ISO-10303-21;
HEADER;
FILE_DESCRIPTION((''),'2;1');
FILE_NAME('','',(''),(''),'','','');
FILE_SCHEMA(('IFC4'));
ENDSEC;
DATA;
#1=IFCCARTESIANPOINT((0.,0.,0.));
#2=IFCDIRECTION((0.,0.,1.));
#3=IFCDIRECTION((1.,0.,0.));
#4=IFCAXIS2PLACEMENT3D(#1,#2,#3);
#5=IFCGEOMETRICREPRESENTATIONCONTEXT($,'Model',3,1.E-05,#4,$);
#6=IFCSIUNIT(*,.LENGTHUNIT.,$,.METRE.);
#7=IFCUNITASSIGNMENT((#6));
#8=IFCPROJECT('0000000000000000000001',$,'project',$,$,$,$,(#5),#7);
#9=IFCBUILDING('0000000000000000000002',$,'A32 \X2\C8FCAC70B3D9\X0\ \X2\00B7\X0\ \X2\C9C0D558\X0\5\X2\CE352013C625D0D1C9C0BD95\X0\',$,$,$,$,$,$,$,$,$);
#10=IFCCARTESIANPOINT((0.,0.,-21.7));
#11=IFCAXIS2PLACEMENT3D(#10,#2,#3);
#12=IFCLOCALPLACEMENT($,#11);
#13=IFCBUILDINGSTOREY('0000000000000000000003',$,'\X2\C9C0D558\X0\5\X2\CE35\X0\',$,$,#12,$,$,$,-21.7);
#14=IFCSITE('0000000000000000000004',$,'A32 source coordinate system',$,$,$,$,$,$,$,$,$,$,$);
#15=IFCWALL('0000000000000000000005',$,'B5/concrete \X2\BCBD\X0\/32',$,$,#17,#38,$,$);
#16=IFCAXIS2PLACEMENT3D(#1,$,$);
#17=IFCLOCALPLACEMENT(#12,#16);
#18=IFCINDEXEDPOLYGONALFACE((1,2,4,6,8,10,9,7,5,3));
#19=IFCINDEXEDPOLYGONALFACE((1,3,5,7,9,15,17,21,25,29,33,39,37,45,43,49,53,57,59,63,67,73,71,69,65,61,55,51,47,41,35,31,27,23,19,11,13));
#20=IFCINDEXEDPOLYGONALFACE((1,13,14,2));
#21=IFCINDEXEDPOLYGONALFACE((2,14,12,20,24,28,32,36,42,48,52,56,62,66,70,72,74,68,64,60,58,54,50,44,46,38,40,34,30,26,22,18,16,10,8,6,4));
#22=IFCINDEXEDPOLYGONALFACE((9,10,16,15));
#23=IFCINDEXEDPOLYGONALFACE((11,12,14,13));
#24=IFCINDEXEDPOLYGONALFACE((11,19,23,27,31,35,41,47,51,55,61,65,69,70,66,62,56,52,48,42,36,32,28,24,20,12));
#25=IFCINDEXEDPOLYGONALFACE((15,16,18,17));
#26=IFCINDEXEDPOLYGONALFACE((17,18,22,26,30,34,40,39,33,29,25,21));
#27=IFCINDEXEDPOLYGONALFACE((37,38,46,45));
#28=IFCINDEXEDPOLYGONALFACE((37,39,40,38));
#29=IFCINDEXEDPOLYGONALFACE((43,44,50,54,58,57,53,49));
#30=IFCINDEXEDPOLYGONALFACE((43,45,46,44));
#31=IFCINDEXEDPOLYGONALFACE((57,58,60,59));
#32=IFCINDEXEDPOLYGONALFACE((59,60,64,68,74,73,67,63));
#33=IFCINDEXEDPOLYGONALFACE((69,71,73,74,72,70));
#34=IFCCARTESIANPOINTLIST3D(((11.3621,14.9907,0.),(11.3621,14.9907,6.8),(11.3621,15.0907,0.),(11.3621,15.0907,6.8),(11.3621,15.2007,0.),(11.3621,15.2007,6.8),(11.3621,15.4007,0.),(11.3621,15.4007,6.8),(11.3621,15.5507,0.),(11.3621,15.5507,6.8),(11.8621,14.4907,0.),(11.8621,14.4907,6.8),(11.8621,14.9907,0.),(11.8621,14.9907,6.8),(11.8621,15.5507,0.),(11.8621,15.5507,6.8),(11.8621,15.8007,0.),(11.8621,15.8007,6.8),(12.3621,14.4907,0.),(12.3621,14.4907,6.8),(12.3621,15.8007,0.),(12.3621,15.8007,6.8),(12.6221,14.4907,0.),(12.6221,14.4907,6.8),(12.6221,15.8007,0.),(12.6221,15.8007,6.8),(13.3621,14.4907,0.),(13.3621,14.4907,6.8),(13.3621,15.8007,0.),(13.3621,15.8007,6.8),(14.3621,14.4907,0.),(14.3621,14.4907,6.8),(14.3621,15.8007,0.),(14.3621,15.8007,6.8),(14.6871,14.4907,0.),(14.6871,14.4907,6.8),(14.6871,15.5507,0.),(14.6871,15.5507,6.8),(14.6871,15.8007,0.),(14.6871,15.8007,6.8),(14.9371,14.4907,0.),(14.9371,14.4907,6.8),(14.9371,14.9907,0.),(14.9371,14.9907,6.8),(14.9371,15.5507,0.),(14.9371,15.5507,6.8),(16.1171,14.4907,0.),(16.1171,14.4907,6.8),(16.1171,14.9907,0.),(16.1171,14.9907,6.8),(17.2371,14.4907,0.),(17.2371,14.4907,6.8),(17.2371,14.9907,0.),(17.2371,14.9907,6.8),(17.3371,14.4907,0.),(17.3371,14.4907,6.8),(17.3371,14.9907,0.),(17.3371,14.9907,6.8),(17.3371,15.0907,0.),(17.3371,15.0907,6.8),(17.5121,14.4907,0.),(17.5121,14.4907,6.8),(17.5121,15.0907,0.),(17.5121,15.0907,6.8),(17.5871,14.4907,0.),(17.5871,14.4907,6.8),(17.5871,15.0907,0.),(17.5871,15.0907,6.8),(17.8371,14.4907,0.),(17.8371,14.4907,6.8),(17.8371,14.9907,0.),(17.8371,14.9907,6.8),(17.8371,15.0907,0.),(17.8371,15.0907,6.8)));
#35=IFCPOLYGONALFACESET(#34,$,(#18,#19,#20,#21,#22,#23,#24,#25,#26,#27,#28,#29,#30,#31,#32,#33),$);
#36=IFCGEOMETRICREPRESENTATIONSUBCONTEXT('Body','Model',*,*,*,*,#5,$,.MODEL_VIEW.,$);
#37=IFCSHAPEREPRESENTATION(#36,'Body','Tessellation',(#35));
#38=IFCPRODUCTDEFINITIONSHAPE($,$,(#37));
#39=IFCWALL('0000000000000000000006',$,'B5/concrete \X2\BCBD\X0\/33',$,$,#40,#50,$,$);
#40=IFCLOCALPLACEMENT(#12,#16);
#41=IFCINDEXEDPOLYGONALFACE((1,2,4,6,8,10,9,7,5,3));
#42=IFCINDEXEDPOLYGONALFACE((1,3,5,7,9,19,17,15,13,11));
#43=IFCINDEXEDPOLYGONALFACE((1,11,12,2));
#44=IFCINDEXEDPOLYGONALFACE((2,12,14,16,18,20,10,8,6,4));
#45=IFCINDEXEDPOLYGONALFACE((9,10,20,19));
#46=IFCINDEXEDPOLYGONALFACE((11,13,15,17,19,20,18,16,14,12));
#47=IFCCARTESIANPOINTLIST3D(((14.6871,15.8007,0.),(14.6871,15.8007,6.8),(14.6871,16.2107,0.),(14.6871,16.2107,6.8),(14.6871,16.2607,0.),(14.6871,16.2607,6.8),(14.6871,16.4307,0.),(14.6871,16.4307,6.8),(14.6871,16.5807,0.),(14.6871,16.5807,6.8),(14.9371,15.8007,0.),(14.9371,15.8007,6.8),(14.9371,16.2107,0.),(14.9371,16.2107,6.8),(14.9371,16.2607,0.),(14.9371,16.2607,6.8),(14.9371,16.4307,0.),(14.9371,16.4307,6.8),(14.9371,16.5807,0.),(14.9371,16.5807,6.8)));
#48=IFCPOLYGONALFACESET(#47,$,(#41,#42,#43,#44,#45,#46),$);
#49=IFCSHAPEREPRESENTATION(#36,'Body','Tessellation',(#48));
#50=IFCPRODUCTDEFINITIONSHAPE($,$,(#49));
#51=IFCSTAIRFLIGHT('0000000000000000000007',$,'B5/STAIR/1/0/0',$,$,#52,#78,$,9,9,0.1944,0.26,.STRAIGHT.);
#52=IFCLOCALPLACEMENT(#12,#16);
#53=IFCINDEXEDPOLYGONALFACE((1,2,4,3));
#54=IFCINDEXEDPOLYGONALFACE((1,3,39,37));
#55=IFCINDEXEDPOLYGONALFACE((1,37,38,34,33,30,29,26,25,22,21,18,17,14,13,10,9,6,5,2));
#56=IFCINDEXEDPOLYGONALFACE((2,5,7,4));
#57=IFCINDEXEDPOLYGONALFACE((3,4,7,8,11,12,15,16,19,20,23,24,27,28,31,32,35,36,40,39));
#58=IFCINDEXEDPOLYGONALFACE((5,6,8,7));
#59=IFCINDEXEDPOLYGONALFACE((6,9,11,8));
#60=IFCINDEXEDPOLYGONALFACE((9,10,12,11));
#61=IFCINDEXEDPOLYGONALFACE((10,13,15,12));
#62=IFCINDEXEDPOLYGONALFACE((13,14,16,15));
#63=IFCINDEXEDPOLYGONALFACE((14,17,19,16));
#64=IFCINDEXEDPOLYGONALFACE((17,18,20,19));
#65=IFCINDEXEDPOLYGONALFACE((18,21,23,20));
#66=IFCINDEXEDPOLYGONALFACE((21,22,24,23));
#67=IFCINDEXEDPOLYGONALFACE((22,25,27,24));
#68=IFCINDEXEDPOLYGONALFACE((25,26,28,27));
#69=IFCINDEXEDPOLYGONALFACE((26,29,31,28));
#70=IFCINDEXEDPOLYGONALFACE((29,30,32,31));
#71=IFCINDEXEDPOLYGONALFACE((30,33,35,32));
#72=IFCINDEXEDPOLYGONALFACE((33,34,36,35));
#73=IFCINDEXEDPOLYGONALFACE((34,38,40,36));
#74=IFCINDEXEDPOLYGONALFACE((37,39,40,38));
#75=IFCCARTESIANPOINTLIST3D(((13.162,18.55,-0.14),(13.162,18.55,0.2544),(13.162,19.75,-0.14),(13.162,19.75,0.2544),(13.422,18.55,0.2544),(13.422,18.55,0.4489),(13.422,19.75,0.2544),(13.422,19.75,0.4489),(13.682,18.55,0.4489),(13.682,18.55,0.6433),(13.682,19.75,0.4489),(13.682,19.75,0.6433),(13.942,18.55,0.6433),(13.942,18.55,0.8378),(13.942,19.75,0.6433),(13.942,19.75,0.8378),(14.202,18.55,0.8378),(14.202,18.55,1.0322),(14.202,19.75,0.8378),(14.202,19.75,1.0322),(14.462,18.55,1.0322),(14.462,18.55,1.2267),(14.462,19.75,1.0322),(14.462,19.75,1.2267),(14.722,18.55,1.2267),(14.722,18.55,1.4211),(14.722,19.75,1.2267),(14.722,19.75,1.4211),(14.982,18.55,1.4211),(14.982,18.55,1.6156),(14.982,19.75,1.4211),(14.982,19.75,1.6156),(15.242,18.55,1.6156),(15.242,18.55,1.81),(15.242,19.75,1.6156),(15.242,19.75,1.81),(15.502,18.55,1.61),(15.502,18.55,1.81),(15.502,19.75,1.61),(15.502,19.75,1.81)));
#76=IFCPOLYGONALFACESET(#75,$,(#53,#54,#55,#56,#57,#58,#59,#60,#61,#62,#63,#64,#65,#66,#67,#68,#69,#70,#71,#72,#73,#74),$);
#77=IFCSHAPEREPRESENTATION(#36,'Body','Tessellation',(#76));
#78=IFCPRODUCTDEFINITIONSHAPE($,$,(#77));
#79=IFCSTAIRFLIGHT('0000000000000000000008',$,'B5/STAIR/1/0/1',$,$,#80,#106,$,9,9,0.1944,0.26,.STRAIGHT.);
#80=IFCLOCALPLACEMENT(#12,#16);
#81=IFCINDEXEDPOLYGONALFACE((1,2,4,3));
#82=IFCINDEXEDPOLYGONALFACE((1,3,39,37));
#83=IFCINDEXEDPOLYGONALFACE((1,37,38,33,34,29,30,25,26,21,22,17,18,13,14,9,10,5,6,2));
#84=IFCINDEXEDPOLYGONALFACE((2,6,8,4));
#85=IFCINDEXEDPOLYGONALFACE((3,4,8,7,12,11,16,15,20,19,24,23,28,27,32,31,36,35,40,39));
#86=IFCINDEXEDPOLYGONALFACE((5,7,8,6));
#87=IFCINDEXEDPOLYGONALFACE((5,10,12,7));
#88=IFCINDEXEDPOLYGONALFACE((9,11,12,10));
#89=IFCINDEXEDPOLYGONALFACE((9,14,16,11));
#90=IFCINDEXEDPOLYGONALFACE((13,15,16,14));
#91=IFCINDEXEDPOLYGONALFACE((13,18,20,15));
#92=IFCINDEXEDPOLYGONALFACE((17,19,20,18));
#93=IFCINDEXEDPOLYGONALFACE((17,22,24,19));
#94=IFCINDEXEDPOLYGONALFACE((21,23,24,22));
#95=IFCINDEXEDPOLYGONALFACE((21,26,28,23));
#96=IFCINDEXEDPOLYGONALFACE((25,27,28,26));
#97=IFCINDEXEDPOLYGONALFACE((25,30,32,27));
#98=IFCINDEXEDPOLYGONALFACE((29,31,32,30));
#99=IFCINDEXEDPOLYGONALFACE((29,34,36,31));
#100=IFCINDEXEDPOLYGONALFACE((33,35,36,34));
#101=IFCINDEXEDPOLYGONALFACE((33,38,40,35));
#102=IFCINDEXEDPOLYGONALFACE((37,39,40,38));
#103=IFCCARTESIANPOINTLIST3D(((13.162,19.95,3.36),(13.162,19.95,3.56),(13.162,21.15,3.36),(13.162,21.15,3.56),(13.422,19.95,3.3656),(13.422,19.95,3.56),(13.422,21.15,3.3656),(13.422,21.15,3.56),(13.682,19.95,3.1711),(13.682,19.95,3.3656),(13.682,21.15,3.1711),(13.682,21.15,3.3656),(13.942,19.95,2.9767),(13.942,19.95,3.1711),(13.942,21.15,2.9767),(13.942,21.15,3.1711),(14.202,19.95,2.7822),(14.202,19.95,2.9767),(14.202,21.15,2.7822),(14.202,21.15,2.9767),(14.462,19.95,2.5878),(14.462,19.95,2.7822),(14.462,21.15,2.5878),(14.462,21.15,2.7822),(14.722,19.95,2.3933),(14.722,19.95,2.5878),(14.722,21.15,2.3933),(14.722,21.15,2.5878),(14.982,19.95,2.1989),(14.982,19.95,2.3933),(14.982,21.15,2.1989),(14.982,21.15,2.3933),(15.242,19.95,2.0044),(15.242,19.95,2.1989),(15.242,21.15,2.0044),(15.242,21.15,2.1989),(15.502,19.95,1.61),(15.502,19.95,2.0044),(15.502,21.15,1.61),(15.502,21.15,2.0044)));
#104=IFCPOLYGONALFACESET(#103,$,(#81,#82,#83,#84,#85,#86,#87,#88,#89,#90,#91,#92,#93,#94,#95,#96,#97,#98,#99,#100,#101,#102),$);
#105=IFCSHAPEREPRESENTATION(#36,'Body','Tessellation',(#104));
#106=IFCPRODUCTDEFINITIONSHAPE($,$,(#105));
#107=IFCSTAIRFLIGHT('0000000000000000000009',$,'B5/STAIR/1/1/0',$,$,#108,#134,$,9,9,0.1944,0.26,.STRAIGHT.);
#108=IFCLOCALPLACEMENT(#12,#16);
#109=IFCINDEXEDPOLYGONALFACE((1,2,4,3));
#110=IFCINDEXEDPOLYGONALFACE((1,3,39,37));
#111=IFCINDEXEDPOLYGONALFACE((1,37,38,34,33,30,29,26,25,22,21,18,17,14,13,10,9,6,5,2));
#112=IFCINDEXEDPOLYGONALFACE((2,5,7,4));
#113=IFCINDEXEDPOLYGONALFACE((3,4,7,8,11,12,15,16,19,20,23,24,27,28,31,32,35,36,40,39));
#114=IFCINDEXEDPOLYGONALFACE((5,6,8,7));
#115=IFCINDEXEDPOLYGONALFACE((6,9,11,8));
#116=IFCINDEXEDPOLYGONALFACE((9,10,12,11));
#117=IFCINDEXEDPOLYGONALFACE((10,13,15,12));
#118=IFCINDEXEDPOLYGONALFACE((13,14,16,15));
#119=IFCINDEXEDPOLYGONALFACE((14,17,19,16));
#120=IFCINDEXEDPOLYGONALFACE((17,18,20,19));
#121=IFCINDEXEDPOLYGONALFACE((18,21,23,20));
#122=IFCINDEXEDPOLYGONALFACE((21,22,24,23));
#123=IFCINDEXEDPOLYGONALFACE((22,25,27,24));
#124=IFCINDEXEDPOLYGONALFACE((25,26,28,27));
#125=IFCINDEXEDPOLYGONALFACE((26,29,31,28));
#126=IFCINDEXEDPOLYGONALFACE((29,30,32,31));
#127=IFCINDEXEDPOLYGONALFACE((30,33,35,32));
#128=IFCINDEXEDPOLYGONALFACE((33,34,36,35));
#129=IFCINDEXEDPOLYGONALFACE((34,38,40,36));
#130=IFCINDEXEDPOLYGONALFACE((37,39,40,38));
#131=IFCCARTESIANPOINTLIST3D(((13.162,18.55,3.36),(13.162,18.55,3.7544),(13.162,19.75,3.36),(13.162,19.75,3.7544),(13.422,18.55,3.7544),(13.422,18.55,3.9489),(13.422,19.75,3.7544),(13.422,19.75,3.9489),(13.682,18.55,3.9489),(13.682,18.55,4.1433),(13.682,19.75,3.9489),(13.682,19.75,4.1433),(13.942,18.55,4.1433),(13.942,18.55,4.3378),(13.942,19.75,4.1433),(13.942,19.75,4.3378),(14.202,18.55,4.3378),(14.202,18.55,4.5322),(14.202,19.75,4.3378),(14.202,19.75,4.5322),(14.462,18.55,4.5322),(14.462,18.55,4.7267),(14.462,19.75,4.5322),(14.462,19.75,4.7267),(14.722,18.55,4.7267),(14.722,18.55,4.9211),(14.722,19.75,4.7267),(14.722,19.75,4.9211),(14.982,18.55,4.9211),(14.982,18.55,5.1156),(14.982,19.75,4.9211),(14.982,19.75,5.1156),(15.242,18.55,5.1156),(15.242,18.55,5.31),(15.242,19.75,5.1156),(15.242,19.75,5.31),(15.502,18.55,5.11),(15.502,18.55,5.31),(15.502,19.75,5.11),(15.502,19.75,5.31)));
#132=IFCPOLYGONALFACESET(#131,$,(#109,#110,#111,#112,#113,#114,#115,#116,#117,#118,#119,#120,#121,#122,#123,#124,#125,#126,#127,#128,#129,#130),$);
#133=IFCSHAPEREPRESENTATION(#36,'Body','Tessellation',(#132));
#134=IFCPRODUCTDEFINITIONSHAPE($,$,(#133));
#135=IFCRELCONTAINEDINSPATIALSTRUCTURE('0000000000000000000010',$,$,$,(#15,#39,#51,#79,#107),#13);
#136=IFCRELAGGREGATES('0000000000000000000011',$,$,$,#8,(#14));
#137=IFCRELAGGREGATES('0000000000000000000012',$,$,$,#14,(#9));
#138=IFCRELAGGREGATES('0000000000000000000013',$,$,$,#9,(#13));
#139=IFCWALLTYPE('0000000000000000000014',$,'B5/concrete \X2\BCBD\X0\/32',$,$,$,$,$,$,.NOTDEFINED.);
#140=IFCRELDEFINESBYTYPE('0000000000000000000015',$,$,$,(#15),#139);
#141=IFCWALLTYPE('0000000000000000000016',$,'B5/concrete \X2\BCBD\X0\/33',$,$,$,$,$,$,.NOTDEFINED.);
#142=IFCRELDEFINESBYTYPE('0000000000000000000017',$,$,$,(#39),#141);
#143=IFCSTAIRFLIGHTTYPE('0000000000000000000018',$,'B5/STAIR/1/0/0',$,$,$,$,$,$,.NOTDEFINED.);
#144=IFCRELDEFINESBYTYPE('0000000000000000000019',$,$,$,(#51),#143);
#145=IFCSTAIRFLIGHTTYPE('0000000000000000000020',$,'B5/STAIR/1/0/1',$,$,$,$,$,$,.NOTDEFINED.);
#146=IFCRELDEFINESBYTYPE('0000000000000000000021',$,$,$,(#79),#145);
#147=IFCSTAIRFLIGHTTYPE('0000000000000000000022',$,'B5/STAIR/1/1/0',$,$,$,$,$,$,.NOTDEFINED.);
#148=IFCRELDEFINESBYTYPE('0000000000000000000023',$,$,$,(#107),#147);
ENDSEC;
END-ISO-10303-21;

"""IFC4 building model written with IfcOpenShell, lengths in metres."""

from ifc_helpers import new_model, si_unit, frame, origin, origin_with_axes, place, context, subcontext, project, spatial, polyline, outline, extrude, source, transform, mapped, type_object, type_shapes, element, save


model = new_model("IFC4")

# Units and contexts
model_context = context("Model", 3, precision=1e-05, world=origin_with_axes())
body_context = subcontext(model_context, "Body", "Model", "MODEL_VIEW")
ifc_project = project(units=[si_unit("LENGTHUNIT", "METRE")], contexts=[model_context])

# Site, building, storey
site = spatial("IfcSite", under=ifc_project, Name="A32 source coordinate system")
building = spatial("IfcBuilding", under=site, Name="A32 주거동 · 지하5층–옥탑지붕")
storey_placement = place(None, frame((0.0, 0.0, -21.7), z_axis=(0.0, 0.0, 1.0), x_axis=(1.0, 0.0, 0.0)))
storey = spatial("IfcBuildingStorey", under=building, at=storey_placement, Name="지하5층", Elevation=-21.7)

# Walls
wall_type_1 = type_object("IfcWallType", Name="B5/concrete 벽/32", PredefinedType="NOTDEFINED")
shared_shape_1 = source(origin(), body_context, "Body", "SweptSolid", [
    extrude(outline(polyline([(11.8621, 15.5507), (11.8621, 15.8007), (12.3621, 15.8007), (12.6221, 15.8007), (13.3621, 15.8007), (14.3621, 15.8007), (14.6871, 15.8007), (14.6871, 15.5507), (14.9371, 15.5507), (14.9371, 14.9907), (16.1171, 14.9907), (17.2371, 14.9907), (17.3371, 14.9907), (17.3371, 15.0907), (17.5121, 15.0907), (17.5871, 15.0907), (17.8371, 15.0907), (17.8371, 14.9907), (17.8371, 14.4907), (17.5871, 14.4907), (17.5121, 14.4907), (17.3371, 14.4907), (17.2371, 14.4907), (16.1171, 14.4907), (14.9371, 14.4907), (14.6871, 14.4907), (14.3621, 14.4907), (13.3621, 14.4907), (12.6221, 14.4907), (12.3621, 14.4907), (11.8621, 14.4907), (11.8621, 14.9907), (11.3621, 14.9907), (11.3621, 15.0907), (11.3621, 15.2007), (11.3621, 15.4007), (11.3621, 15.5507), (11.8621, 15.5507)])), origin(), (0.0, 0.0, 1.0), 6.8),
])
type_shapes(wall_type_1, [shared_shape_1])
wall_1_placement = place(storey_placement, origin_with_axes())
element("IfcWall", 1, at=wall_1_placement, inside=storey, type_object=wall_type_1, Name="B5/concrete 벽/32", context=body_context, shape_type="MappedRepresentation", body=[
    mapped(shared_shape_1, transform((0.0, 0.0, 0.0), scale=1.0)),
])
wall_type_2 = type_object("IfcWallType", Name="B5/concrete 벽/33", PredefinedType="NOTDEFINED")
shared_shape_2 = source(origin(), body_context, "Body", "SweptSolid", [
    extrude(outline(polyline([(14.6871, 16.4307), (14.6871, 16.5807), (14.9371, 16.5807), (14.9371, 16.4307), (14.9371, 16.2607), (14.9371, 16.2107), (14.9371, 15.8007), (14.6871, 15.8007), (14.6871, 16.2107), (14.6871, 16.2607), (14.6871, 16.4307)])), origin(), (0.0, 0.0, 1.0), 6.8),
])
type_shapes(wall_type_2, [shared_shape_2])
wall_2_placement = place(storey_placement, origin_with_axes())
element("IfcWall", 2, at=wall_2_placement, inside=storey, type_object=wall_type_2, Name="B5/concrete 벽/33", context=body_context, shape_type="MappedRepresentation", body=[
    mapped(shared_shape_2, transform((0.0, 0.0, 0.0), scale=1.0)),
])

# Stair flights
stair_flight_type_1 = type_object("IfcStairFlightType", Name="B5/STAIR/1/0/0", PredefinedType="NOTDEFINED")
shared_shape_3 = source(origin(), body_context, "Body", "SweptSolid", [
    extrude(outline(polyline([(0.0, -0.14), (2.34, 1.61), (2.34, 1.81), (2.08, 1.81), (2.08, 1.6156), (1.82, 1.6156), (1.82, 1.4211), (1.56, 1.4211), (1.56, 1.2267), (1.3, 1.2267), (1.3, 1.0322), (1.04, 1.0322), (1.04, 0.8378), (0.78, 0.8378), (0.78, 0.6433), (0.52, 0.6433), (0.52, 0.4489), (0.26, 0.4489), (0.26, 0.2544), (0.0, 0.2544), (0.0, -0.14)])), frame((13.162, 19.75, 0.0), z_axis=(0.0, -1.0, 0.0), x_axis=(1.0, 0.0, 0.0)), (0.0, 0.0, 1.0), 1.2),
])
type_shapes(stair_flight_type_1, [shared_shape_3])
stair_flight_1_placement = place(storey_placement, origin_with_axes())
element("IfcStairFlight", 3, at=stair_flight_1_placement, inside=storey, type_object=stair_flight_type_1, Name="B5/STAIR/1/0/0", NumberOfRisers=9, NumberOfTreads=9, PredefinedType="STRAIGHT", RiserHeight=0.1944, TreadLength=0.26, context=body_context, shape_type="MappedRepresentation", body=[
    mapped(shared_shape_3, transform((0.0, 0.0, 0.0), scale=1.0)),
])
stair_flight_type_2 = type_object("IfcStairFlightType", Name="B5/STAIR/1/0/1", PredefinedType="NOTDEFINED")
shared_shape_4 = source(origin(), body_context, "Body", "SweptSolid", [
    extrude(outline(polyline([(0.0, 1.61), (2.34, 3.36), (2.34, 3.56), (2.08, 3.56), (2.08, 3.3656), (1.82, 3.3656), (1.82, 3.1711), (1.56, 3.1711), (1.56, 2.9767), (1.3, 2.9767), (1.3, 2.7822), (1.04, 2.7822), (1.04, 2.5878), (0.78, 2.5878), (0.78, 2.3933), (0.52, 2.3933), (0.52, 2.1989), (0.26, 2.1989), (0.26, 2.0044), (0.0, 2.0044), (0.0, 1.61)])), frame((15.502, 19.95, 0.0), z_axis=(0.0, 1.0, 0.0), x_axis=(-1.0, 0.0, 0.0)), (0.0, 0.0, 1.0), 1.2),
])
type_shapes(stair_flight_type_2, [shared_shape_4])
stair_flight_2_placement = place(storey_placement, origin_with_axes())
element("IfcStairFlight", 4, at=stair_flight_2_placement, inside=storey, type_object=stair_flight_type_2, Name="B5/STAIR/1/0/1", NumberOfRisers=9, NumberOfTreads=9, PredefinedType="STRAIGHT", RiserHeight=0.1944, TreadLength=0.26, context=body_context, shape_type="MappedRepresentation", body=[
    mapped(shared_shape_4, transform((0.0, 0.0, 0.0), scale=1.0)),
])
stair_flight_type_3 = type_object("IfcStairFlightType", Name="B5/STAIR/1/1/0", PredefinedType="NOTDEFINED")
shared_shape_5 = source(origin(), body_context, "Body", "SweptSolid", [
    extrude(outline(polyline([(0.0, 3.36), (2.34, 5.11), (2.34, 5.31), (2.08, 5.31), (2.08, 5.1156), (1.82, 5.1156), (1.82, 4.9211), (1.56, 4.9211), (1.56, 4.7267), (1.3, 4.7267), (1.3, 4.5322), (1.04, 4.5322), (1.04, 4.3378), (0.78, 4.3378), (0.78, 4.1433), (0.52, 4.1433), (0.52, 3.9489), (0.26, 3.9489), (0.26, 3.7544), (0.0, 3.7544), (0.0, 3.36)])), frame((13.162, 19.75, 0.0), z_axis=(0.0, -1.0, 0.0), x_axis=(1.0, 0.0, 0.0)), (0.0, 0.0, 1.0), 1.2),
])
type_shapes(stair_flight_type_3, [shared_shape_5])
stair_flight_3_placement = place(storey_placement, origin_with_axes())
element("IfcStairFlight", 5, at=stair_flight_3_placement, inside=storey, type_object=stair_flight_type_3, Name="B5/STAIR/1/1/0", NumberOfRisers=9, NumberOfTreads=9, PredefinedType="STRAIGHT", RiserHeight=0.1944, TreadLength=0.26, context=body_context, shape_type="MappedRepresentation", body=[
    mapped(shared_shape_5, transform((0.0, 0.0, 0.0), scale=1.0)),
])

save(model, "model.ifc")
